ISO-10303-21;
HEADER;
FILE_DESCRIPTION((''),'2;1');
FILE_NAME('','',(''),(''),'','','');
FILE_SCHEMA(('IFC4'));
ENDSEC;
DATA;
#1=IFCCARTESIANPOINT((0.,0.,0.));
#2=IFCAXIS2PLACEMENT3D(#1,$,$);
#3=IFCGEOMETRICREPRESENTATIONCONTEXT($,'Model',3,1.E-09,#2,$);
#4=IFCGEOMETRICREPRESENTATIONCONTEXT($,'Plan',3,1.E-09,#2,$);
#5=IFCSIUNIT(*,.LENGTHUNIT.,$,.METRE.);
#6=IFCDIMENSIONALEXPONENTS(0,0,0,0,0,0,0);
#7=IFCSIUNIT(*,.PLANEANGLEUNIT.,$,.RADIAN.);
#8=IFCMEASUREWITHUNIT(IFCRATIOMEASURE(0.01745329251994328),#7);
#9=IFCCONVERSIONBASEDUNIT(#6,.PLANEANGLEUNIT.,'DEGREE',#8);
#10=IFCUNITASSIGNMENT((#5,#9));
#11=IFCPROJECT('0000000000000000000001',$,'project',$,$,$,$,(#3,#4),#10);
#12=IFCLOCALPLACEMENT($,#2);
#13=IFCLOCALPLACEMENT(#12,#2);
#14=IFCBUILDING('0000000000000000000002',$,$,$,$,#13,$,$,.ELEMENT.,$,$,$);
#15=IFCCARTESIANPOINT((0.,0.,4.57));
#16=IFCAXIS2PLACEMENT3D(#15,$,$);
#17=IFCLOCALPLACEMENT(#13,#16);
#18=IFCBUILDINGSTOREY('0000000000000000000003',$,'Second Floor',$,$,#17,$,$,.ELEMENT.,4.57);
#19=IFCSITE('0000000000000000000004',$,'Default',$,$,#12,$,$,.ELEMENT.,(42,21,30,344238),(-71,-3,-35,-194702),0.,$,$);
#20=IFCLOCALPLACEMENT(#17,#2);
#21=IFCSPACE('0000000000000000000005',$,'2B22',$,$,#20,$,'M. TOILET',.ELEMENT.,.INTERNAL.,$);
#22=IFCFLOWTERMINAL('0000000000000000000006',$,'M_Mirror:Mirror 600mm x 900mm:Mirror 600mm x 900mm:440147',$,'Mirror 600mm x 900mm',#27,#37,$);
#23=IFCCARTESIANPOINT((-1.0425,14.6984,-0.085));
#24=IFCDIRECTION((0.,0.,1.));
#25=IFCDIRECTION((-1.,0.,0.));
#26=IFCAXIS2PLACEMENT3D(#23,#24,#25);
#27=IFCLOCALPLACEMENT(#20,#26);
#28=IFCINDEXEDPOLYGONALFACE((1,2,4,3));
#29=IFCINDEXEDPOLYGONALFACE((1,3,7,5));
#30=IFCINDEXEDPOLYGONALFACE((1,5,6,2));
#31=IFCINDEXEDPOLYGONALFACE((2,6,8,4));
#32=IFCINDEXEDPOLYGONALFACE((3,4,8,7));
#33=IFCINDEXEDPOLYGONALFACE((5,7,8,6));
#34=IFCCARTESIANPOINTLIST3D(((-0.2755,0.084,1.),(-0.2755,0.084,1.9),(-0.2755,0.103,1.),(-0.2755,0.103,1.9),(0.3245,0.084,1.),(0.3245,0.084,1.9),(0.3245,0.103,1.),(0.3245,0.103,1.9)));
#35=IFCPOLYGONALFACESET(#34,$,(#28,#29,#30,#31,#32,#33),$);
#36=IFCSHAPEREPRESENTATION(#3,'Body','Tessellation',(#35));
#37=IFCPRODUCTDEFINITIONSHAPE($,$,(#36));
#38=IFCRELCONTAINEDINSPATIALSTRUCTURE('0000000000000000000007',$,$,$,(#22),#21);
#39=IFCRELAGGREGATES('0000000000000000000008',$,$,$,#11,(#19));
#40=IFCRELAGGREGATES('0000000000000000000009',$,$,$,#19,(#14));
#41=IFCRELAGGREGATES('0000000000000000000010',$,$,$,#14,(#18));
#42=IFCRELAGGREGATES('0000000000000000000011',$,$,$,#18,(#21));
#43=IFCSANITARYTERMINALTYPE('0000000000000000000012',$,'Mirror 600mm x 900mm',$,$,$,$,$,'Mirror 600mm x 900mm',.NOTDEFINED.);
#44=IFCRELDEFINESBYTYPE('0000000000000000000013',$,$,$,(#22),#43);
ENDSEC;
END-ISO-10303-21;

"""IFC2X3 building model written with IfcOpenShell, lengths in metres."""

from ifc_helpers import new_model, entity, si_unit, converted_unit, frame, origin, origin_2d_with_axis, place, context, project, spatial, rectangle, extrude, source, transform, mapped, type_object, type_shapes, element, save


model = new_model("IFC2X3")

# Units and contexts
model_context = context("Model", 3, precision=1e-09, world=origin())
plan_context = context("Plan", 3, precision=1e-09, world=origin())
ifc_project = project(units=[si_unit("LENGTHUNIT", "METRE"), converted_unit("PLANEANGLEUNIT", "DEGREE", entity("IfcRatioMeasure", 0.01745329251994328), si_unit("PLANEANGLEUNIT", "RADIAN"), dimensions=[0, 0, 0, 0, 0, 0, 0])], contexts=[model_context, plan_context])

# Site, building, storey
site_placement = place(None, origin())
site = spatial("IfcSite", under=ifc_project, at=site_placement, Name="Default", CompositionType="ELEMENT", RefLatitude=(42, 21, 30, 344238), RefLongitude=(-71, -3, -35, -194702), RefElevation=0.0)
building_placement = place(site_placement, origin())
building = spatial("IfcBuilding", under=site, at=building_placement, CompositionType="ELEMENT")
storey_placement = place(building_placement, frame((0.0, 0.0, 4.57)))
storey = spatial("IfcBuildingStorey", under=building, at=storey_placement, Name="Second Floor", CompositionType="ELEMENT", Elevation=4.57)

# Shared definitions
space_placement = place(storey_placement, origin())
space = spatial("IfcSpace", under=storey, at=space_placement, Name="2B22", LongName="M. TOILET", CompositionType="ELEMENT", InteriorOrExteriorSpace="INTERNAL")

# Flow terminal
sanitary_terminal_type = type_object("IfcSanitaryTerminalType", Name="Mirror 600mm x 900mm", ElementType="Mirror 600mm x 900mm", PredefinedType="NOTDEFINED")
shared_shape_1 = source(origin(), model_context, "Body", "SweptSolid", [
    extrude(rectangle(XDim=0.0191, YDim=0.6, at=origin_2d_with_axis()), frame((0.0245, 0.0935, 1.0), z_axis=(0.0, 0.0, 1.0), x_axis=(0.0, -1.0, 0.0)), (0.0, 0.0, 1.0), 0.9),
])
type_shapes(sanitary_terminal_type, [shared_shape_1])
flow_terminal_placement = place(space_placement, frame((-1.0425, 14.6984, -0.085), z_axis=(0.0, 0.0, 1.0), x_axis=(-1.0, 0.0, 0.0)))
element("IfcFlowTerminal", 1, at=flow_terminal_placement, inside=space, type_object=sanitary_terminal_type, Name="M_Mirror:Mirror 600mm x 900mm:Mirror 600mm x 900mm:440147", ObjectType="Mirror 600mm x 900mm", context=model_context, shape_type="MappedRepresentation", body=[
    mapped(shared_shape_1, transform((0.0, 0.0, 0.0), scale=1.0)),
])

save(model, "model.ifc")
